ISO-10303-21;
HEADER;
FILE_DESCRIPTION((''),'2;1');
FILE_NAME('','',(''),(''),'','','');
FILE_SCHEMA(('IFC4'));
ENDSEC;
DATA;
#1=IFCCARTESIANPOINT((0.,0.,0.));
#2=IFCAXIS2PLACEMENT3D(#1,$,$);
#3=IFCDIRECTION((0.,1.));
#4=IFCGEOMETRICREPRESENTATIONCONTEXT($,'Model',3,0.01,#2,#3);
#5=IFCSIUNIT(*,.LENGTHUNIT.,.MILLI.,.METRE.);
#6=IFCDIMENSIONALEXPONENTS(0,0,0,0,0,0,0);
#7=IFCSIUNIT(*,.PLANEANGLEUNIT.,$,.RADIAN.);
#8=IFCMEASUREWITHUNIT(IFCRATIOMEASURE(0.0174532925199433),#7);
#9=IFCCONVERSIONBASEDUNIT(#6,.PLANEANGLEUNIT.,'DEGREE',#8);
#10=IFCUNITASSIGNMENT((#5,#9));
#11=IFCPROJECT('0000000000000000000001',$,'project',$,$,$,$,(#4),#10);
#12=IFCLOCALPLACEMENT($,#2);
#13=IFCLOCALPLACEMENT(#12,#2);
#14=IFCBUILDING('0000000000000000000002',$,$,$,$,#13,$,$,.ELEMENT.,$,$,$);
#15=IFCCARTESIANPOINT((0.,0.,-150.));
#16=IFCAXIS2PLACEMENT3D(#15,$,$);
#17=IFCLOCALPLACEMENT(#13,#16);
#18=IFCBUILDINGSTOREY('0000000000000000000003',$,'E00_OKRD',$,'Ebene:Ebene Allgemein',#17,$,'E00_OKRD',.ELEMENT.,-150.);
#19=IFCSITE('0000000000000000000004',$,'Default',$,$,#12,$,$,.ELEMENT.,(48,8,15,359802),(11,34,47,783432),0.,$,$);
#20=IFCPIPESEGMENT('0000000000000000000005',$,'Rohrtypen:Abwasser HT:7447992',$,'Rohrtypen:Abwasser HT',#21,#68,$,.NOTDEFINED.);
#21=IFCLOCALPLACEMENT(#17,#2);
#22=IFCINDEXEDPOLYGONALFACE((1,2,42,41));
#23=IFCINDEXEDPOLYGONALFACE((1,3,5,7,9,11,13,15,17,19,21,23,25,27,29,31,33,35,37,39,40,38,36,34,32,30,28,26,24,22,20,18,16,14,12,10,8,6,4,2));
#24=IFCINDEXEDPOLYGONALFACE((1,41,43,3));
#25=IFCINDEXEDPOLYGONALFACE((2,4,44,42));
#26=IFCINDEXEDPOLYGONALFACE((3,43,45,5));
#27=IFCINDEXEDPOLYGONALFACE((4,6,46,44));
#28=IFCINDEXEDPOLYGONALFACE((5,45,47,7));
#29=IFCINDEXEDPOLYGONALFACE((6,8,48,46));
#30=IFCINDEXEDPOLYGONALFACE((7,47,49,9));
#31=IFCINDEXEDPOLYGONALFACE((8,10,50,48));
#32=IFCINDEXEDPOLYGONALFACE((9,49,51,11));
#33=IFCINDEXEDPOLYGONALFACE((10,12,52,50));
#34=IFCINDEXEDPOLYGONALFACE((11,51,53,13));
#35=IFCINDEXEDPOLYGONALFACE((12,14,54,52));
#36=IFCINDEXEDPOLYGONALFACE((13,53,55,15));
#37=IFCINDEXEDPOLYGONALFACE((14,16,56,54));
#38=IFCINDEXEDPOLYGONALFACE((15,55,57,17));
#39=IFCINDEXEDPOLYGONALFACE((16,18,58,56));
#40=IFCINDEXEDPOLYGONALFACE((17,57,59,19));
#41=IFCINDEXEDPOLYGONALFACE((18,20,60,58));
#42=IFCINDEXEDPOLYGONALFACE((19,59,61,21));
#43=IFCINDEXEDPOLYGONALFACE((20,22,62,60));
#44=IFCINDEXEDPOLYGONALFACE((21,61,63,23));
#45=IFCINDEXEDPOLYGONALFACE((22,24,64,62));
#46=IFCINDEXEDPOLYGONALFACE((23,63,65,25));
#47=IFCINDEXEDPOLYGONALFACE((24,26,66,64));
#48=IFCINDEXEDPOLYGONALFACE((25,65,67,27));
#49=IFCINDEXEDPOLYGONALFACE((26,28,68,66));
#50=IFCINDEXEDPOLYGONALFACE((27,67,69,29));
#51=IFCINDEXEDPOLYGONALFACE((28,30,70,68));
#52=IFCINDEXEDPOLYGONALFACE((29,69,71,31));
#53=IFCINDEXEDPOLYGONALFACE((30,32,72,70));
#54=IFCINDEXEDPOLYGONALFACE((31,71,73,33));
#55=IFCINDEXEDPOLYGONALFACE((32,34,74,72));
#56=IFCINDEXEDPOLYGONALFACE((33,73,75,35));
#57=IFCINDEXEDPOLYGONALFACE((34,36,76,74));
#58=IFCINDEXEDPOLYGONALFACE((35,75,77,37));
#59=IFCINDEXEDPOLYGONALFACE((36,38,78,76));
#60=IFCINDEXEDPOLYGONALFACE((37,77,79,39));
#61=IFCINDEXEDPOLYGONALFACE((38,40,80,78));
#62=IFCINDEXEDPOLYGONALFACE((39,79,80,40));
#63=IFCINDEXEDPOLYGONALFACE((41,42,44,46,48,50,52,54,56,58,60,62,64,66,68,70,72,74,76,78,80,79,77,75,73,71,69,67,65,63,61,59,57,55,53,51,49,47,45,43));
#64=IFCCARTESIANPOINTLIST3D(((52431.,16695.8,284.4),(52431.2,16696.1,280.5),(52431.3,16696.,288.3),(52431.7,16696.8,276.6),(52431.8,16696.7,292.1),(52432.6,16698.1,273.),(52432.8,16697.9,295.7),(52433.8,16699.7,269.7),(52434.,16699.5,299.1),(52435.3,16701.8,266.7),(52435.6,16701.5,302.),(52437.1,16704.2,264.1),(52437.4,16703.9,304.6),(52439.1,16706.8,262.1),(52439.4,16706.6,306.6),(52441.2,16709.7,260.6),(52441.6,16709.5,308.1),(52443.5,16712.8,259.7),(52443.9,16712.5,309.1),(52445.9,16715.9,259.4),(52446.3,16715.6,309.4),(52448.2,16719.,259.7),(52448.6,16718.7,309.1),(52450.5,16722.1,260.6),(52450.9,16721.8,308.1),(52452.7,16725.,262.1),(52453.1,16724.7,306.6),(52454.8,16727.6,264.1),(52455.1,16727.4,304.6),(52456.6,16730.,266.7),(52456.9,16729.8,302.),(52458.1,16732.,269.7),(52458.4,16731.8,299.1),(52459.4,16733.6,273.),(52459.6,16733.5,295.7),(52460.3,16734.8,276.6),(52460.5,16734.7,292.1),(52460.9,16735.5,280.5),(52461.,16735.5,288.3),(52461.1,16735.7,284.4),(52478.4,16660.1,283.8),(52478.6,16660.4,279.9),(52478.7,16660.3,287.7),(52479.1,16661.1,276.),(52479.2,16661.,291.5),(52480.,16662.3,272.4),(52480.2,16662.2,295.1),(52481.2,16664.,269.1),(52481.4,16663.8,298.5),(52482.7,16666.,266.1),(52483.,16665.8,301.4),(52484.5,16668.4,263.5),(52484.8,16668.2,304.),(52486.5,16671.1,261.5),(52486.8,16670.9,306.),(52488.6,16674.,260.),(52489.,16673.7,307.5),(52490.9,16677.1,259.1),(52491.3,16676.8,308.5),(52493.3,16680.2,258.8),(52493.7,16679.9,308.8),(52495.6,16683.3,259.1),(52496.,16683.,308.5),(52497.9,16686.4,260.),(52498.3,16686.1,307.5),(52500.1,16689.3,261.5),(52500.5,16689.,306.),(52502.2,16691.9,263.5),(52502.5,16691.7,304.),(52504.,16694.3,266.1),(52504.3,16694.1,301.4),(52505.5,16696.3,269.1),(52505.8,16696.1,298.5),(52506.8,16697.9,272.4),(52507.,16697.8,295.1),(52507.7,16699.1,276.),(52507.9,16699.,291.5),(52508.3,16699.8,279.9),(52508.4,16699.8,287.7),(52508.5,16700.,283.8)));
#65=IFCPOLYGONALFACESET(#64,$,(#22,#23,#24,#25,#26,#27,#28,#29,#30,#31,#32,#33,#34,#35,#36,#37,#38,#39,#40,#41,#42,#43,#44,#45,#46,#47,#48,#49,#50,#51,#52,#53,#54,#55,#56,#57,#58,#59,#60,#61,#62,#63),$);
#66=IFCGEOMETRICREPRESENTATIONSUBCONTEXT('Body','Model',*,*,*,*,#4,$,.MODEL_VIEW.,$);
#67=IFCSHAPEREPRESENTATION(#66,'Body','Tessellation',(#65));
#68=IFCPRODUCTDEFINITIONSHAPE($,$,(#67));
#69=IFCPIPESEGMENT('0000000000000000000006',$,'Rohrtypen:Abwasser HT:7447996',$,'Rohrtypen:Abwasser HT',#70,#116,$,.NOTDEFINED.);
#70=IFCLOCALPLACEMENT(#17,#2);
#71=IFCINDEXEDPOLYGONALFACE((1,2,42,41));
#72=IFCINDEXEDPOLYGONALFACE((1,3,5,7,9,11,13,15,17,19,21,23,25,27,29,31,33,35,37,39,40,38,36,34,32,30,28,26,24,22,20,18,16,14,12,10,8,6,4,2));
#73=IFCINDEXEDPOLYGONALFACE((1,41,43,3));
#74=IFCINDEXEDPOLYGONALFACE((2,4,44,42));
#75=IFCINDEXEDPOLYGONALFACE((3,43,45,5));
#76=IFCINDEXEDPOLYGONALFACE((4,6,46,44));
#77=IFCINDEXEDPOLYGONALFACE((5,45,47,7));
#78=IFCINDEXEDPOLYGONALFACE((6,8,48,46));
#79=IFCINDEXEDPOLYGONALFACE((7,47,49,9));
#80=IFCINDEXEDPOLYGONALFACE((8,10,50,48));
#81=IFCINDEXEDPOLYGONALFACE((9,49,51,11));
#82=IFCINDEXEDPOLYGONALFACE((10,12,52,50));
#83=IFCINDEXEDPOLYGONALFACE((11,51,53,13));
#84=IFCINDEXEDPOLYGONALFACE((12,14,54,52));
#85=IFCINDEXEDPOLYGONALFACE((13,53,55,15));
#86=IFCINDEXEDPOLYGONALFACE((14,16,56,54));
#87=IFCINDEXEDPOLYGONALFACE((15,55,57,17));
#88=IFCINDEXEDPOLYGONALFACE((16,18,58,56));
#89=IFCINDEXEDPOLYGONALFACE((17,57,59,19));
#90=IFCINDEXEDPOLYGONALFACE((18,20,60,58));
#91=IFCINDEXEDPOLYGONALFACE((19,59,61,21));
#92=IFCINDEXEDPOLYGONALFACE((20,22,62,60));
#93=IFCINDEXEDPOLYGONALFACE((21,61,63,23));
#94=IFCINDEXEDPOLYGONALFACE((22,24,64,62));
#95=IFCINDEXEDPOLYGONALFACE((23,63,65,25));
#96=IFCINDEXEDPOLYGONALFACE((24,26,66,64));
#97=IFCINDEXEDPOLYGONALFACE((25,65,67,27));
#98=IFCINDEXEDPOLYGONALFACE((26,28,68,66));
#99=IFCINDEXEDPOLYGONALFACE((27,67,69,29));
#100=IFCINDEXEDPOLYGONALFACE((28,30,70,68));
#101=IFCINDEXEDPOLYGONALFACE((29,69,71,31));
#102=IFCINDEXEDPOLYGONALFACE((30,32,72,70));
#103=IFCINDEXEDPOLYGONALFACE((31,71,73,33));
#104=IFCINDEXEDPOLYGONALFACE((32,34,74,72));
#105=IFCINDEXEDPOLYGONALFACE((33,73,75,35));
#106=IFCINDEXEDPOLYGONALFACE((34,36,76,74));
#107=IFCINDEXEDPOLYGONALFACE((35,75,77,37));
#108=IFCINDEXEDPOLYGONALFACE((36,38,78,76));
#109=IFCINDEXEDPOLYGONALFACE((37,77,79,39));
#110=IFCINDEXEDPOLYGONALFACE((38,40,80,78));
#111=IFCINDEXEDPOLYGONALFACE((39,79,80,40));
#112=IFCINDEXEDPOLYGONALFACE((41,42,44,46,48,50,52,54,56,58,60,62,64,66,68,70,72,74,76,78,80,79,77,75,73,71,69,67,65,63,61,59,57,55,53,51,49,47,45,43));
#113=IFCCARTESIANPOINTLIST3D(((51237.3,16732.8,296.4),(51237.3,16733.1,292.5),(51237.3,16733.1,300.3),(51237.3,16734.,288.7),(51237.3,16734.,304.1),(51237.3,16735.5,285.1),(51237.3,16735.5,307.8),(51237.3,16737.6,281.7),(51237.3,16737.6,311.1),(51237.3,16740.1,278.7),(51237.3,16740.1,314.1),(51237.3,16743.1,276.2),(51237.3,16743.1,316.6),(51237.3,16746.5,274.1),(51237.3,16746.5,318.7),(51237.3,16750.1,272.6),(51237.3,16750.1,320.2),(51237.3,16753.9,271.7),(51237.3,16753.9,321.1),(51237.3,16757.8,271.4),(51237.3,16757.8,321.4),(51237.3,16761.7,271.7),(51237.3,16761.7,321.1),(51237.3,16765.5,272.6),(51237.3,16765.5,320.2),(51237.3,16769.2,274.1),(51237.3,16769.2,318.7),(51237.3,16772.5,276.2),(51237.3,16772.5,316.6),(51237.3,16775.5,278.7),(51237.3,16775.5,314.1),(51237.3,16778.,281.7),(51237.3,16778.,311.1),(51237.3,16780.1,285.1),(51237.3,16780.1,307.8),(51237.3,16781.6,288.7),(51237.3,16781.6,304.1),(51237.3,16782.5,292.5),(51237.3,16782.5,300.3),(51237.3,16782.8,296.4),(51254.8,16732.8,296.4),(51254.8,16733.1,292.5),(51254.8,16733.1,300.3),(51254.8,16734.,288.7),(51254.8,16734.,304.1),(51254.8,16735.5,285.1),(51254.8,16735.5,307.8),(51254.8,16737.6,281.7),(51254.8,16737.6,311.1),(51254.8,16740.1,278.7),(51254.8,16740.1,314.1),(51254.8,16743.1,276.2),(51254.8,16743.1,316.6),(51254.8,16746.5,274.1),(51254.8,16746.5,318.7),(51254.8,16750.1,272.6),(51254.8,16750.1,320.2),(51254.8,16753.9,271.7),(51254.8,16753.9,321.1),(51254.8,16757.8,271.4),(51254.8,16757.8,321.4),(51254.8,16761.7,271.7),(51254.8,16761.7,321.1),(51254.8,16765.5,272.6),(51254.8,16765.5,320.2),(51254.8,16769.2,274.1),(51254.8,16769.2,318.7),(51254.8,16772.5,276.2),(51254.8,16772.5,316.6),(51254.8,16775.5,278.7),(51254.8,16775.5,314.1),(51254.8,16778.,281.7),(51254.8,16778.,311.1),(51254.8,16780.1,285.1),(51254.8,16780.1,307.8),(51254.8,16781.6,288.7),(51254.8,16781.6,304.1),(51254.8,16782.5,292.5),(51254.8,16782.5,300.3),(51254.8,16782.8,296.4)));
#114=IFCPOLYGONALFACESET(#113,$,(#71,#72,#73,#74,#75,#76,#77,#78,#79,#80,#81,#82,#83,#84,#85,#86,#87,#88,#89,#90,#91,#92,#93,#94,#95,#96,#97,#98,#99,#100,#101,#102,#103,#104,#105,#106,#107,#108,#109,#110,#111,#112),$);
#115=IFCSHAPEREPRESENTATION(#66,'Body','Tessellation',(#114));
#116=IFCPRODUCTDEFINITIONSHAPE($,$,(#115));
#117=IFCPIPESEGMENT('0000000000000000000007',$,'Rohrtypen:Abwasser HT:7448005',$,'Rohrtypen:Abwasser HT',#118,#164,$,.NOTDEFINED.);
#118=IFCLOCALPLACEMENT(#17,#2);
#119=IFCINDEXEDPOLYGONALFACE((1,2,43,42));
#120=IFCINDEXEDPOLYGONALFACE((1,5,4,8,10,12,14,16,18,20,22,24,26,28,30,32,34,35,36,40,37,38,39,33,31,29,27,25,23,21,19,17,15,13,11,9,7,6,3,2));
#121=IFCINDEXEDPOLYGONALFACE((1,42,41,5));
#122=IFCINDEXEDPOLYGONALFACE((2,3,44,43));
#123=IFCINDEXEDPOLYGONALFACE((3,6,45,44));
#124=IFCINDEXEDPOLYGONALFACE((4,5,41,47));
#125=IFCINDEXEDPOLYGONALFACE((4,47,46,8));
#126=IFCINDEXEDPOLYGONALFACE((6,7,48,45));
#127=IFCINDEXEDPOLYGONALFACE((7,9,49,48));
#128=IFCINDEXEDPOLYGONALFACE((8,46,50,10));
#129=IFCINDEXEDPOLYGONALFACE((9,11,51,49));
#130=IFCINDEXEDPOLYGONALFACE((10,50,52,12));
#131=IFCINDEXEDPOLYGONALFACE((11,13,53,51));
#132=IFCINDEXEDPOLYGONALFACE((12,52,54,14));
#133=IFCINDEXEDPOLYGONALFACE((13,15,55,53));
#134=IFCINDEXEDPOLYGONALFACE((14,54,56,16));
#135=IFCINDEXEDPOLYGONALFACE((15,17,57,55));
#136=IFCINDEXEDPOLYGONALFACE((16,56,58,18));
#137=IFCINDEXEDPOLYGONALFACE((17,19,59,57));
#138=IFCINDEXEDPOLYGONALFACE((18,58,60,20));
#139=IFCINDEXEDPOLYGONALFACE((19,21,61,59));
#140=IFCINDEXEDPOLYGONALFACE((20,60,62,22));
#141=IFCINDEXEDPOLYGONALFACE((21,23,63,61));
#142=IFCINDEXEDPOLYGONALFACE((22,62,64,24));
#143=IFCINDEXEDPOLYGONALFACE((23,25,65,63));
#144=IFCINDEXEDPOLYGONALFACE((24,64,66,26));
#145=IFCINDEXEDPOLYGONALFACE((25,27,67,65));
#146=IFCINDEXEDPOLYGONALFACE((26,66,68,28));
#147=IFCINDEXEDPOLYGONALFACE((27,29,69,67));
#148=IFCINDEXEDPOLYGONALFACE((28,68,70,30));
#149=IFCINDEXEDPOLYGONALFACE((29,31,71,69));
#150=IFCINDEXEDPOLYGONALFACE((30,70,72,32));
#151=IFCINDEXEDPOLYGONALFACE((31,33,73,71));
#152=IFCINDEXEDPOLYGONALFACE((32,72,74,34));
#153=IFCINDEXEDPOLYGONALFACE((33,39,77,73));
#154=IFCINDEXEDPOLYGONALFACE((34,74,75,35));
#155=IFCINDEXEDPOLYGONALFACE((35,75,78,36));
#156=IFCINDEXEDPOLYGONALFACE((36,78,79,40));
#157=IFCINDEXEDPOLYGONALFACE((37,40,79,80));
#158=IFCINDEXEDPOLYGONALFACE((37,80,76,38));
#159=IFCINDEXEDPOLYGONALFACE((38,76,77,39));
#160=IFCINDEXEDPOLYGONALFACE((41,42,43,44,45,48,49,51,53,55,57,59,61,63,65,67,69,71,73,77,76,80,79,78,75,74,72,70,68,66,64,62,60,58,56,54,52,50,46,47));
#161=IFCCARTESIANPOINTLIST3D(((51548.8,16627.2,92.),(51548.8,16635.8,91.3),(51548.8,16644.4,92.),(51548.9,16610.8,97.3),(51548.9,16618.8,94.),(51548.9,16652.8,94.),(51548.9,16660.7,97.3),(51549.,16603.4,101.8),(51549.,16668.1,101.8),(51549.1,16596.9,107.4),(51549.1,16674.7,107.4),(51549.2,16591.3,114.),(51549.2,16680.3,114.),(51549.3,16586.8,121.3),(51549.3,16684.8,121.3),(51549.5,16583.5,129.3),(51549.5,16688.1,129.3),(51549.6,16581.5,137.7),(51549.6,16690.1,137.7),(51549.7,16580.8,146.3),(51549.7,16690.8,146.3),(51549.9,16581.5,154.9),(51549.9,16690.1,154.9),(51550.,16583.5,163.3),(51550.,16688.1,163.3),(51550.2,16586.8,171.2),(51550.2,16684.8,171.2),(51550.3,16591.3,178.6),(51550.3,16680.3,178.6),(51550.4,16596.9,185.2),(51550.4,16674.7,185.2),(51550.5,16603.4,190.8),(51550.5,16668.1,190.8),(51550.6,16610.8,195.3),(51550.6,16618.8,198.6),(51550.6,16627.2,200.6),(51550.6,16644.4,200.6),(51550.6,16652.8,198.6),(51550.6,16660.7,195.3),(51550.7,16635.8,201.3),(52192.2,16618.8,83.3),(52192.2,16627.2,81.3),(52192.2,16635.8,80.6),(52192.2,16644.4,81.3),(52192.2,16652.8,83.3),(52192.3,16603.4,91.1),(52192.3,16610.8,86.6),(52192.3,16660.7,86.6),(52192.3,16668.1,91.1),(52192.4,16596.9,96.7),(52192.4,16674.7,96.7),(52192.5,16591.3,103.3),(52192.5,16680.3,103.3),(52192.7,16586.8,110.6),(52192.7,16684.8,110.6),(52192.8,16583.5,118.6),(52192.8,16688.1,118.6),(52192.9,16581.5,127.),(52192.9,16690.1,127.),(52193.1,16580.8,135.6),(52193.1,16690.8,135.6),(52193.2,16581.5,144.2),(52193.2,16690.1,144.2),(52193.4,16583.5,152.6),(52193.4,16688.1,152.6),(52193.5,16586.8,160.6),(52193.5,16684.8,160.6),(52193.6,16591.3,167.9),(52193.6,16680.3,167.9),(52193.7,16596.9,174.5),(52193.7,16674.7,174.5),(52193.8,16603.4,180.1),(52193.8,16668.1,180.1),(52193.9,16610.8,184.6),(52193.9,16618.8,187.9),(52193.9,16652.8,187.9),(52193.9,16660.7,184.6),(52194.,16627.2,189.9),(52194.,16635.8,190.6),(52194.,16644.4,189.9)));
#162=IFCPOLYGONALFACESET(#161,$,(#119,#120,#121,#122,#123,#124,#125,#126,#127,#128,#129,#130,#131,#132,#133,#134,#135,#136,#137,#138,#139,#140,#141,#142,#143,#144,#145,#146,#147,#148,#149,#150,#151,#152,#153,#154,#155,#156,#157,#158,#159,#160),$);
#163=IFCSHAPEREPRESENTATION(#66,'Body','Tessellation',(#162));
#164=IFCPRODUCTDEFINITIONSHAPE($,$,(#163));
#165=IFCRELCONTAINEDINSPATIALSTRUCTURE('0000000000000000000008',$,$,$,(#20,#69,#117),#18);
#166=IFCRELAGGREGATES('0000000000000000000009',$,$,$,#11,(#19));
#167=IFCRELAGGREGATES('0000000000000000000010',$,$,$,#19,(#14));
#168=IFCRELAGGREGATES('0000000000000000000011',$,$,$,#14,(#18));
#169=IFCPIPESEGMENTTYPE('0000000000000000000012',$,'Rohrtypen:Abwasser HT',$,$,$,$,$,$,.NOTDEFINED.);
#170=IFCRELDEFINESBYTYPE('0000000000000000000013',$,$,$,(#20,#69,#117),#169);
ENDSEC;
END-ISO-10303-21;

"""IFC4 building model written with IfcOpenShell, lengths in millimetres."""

from ifc_helpers import new_model, entity, si_unit, converted_unit, direction, frame, origin, place, context, subcontext, project, spatial, indexed_curve, outline, extrude, type_object, element, save


model = new_model("IFC4")

# Units and contexts
model_context = context("Model", 3, precision=0.01, world=origin(), true_north=direction((0.0, 1.0)))
body_context = subcontext(model_context, "Body", "Model", "MODEL_VIEW")
ifc_project = project(units=[si_unit("LENGTHUNIT", "METRE", prefix="MILLI"), converted_unit("PLANEANGLEUNIT", "DEGREE", entity("IfcRatioMeasure", 0.0174532925199433), si_unit("PLANEANGLEUNIT", "RADIAN"), dimensions=[0, 0, 0, 0, 0, 0, 0])], contexts=[model_context])

# Site, building, storey
site_placement = place(None, origin())
site = spatial("IfcSite", under=ifc_project, at=site_placement, Name="Default", CompositionType="ELEMENT", RefLatitude=(48, 8, 15, 359802), RefLongitude=(11, 34, 47, 783432), RefElevation=0.0)
building_placement = place(site_placement, origin())
building = spatial("IfcBuilding", under=site, at=building_placement, CompositionType="ELEMENT")
storey_placement = place(building_placement, frame((0.0, 0.0, -150.0)))
storey = spatial("IfcBuildingStorey", under=building, at=storey_placement, Name="E00_OKRD", ObjectType="Ebene:Ebene Allgemein", LongName="E00_OKRD", CompositionType="ELEMENT", Elevation=-150.0)

# Pipe segments
pipe_segment_type_1 = type_object("IfcPipeSegmentType", Name="Rohrtypen:Abwasser HT", PredefinedType="NOTDEFINED")
pipe_segment_1_placement = place(storey_placement, origin())
element("IfcPipeSegment", 1, at=pipe_segment_1_placement, inside=storey, type_object=pipe_segment_type_1, Name="Rohrtypen:Abwasser HT:7447992", ObjectType="Rohrtypen:Abwasser HT", PredefinedType="NOTDEFINED", context=body_context, shape_type="SweptSolid", body=[
    extrude(outline(indexed_curve([(25.0, 0.0), (24.7, 3.9), (23.8, 7.7), (22.3, 11.3), (20.2, 14.7), (17.7, 17.7), (14.7, 20.2), (11.3, 22.3), (7.7, 23.8), (3.9, 24.7), (0.0, 25.0), (-3.9, 24.7), (-7.7, 23.8), (-11.3, 22.3), (-14.7, 20.2), (-17.7, 17.7), (-20.2, 14.7), (-22.3, 11.3), (-23.8, 7.7), (-24.7, 3.9), (-25.0, 0.0), (-24.7, -3.9), (-23.8, -7.7), (-22.3, -11.3), (-20.2, -14.7), (-17.7, -17.7), (-14.7, -20.2), (-11.3, -22.3), (-7.7, -23.8), (-3.9, -24.7), (0.0, -25.0), (3.9, -24.7), (7.7, -23.8), (11.3, -22.3), (14.7, -20.2), (17.7, -17.7), (20.2, -14.7), (22.3, -11.3), (23.8, -7.7), (24.7, -3.9), (25.0, 0.0)], self_intersect=False)), frame((52493.5, 16680.1, 283.8), z_axis=(-0.798581, 0.601804, 0.01), x_axis=(0.601834, 0.798621, 0.0)), (0.0, 0.0, 1.0), 59.3),
])
pipe_segment_2_placement = place(storey_placement, origin())
element("IfcPipeSegment", 2, at=pipe_segment_2_placement, inside=storey, type_object=pipe_segment_type_1, Name="Rohrtypen:Abwasser HT:7447996", ObjectType="Rohrtypen:Abwasser HT", PredefinedType="NOTDEFINED", context=body_context, shape_type="SweptSolid", body=[
    extrude(outline(indexed_curve([(25.0, 0.0), (24.7, 3.9), (23.8, 7.7), (22.3, 11.3), (20.2, 14.7), (17.7, 17.7), (14.7, 20.2), (11.3, 22.3), (7.7, 23.8), (3.9, 24.7), (0.0, 25.0), (-3.9, 24.7), (-7.7, 23.8), (-11.3, 22.3), (-14.7, 20.2), (-17.7, 17.7), (-20.2, 14.7), (-22.3, 11.3), (-23.8, 7.7), (-24.7, 3.9), (-25.0, 0.0), (-24.7, -3.9), (-23.8, -7.7), (-22.3, -11.3), (-20.2, -14.7), (-17.7, -17.7), (-14.7, -20.2), (-11.3, -22.3), (-7.7, -23.8), (-3.9, -24.7), (0.0, -25.0), (3.9, -24.7), (7.7, -23.8), (11.3, -22.3), (14.7, -20.2), (17.7, -17.7), (20.2, -14.7), (22.3, -11.3), (23.8, -7.7), (24.7, -3.9), (25.0, 0.0)], self_intersect=False)), frame((51237.3, 16757.8, 296.4), z_axis=(1.0, 0.0, 0.0), x_axis=(0.0, 1.0, 0.0)), (0.0, 0.0, 1.0), 17.5),
])
pipe_segment_3_placement = place(storey_placement, origin())
element("IfcPipeSegment", 3, at=pipe_segment_3_placement, inside=storey, type_object=pipe_segment_type_1, Name="Rohrtypen:Abwasser HT:7448005", ObjectType="Rohrtypen:Abwasser HT", PredefinedType="NOTDEFINED", context=body_context, shape_type="SweptSolid", body=[
    extrude(outline(indexed_curve([(55.0, 0.0), (54.3, 8.6), (52.3, 17.0), (49.0, 25.0), (44.5, 32.3), (38.9, 38.9), (32.3, 44.5), (25.0, 49.0), (17.0, 52.3), (8.6, 54.3), (0.0, 55.0), (-8.6, 54.3), (-17.0, 52.3), (-25.0, 49.0), (-32.3, 44.5), (-38.9, 38.9), (-44.5, 32.3), (-49.0, 25.0), (-52.3, 17.0), (-54.3, 8.6), (-55.0, 0.0), (-54.3, -8.6), (-52.3, -17.0), (-49.0, -25.0), (-44.5, -32.3), (-38.9, -38.9), (-32.3, -44.5), (-25.0, -49.0), (-17.0, -52.3), (-8.6, -54.3), (0.0, -55.0), (8.6, -54.3), (17.0, -52.3), (25.0, -49.0), (32.3, -44.5), (38.9, -38.9), (44.5, -32.3), (49.0, -25.0), (52.3, -17.0), (54.3, -8.6), (55.0, 0.0)], self_intersect=False)), frame((51549.7, 16635.8, 146.3), z_axis=(0.999862, 0.0, -0.016604), x_axis=(0.0, 1.0, 0.0)), (0.0, 0.0, 1.0), 643.4),
])

save(model, "model.ifc")
